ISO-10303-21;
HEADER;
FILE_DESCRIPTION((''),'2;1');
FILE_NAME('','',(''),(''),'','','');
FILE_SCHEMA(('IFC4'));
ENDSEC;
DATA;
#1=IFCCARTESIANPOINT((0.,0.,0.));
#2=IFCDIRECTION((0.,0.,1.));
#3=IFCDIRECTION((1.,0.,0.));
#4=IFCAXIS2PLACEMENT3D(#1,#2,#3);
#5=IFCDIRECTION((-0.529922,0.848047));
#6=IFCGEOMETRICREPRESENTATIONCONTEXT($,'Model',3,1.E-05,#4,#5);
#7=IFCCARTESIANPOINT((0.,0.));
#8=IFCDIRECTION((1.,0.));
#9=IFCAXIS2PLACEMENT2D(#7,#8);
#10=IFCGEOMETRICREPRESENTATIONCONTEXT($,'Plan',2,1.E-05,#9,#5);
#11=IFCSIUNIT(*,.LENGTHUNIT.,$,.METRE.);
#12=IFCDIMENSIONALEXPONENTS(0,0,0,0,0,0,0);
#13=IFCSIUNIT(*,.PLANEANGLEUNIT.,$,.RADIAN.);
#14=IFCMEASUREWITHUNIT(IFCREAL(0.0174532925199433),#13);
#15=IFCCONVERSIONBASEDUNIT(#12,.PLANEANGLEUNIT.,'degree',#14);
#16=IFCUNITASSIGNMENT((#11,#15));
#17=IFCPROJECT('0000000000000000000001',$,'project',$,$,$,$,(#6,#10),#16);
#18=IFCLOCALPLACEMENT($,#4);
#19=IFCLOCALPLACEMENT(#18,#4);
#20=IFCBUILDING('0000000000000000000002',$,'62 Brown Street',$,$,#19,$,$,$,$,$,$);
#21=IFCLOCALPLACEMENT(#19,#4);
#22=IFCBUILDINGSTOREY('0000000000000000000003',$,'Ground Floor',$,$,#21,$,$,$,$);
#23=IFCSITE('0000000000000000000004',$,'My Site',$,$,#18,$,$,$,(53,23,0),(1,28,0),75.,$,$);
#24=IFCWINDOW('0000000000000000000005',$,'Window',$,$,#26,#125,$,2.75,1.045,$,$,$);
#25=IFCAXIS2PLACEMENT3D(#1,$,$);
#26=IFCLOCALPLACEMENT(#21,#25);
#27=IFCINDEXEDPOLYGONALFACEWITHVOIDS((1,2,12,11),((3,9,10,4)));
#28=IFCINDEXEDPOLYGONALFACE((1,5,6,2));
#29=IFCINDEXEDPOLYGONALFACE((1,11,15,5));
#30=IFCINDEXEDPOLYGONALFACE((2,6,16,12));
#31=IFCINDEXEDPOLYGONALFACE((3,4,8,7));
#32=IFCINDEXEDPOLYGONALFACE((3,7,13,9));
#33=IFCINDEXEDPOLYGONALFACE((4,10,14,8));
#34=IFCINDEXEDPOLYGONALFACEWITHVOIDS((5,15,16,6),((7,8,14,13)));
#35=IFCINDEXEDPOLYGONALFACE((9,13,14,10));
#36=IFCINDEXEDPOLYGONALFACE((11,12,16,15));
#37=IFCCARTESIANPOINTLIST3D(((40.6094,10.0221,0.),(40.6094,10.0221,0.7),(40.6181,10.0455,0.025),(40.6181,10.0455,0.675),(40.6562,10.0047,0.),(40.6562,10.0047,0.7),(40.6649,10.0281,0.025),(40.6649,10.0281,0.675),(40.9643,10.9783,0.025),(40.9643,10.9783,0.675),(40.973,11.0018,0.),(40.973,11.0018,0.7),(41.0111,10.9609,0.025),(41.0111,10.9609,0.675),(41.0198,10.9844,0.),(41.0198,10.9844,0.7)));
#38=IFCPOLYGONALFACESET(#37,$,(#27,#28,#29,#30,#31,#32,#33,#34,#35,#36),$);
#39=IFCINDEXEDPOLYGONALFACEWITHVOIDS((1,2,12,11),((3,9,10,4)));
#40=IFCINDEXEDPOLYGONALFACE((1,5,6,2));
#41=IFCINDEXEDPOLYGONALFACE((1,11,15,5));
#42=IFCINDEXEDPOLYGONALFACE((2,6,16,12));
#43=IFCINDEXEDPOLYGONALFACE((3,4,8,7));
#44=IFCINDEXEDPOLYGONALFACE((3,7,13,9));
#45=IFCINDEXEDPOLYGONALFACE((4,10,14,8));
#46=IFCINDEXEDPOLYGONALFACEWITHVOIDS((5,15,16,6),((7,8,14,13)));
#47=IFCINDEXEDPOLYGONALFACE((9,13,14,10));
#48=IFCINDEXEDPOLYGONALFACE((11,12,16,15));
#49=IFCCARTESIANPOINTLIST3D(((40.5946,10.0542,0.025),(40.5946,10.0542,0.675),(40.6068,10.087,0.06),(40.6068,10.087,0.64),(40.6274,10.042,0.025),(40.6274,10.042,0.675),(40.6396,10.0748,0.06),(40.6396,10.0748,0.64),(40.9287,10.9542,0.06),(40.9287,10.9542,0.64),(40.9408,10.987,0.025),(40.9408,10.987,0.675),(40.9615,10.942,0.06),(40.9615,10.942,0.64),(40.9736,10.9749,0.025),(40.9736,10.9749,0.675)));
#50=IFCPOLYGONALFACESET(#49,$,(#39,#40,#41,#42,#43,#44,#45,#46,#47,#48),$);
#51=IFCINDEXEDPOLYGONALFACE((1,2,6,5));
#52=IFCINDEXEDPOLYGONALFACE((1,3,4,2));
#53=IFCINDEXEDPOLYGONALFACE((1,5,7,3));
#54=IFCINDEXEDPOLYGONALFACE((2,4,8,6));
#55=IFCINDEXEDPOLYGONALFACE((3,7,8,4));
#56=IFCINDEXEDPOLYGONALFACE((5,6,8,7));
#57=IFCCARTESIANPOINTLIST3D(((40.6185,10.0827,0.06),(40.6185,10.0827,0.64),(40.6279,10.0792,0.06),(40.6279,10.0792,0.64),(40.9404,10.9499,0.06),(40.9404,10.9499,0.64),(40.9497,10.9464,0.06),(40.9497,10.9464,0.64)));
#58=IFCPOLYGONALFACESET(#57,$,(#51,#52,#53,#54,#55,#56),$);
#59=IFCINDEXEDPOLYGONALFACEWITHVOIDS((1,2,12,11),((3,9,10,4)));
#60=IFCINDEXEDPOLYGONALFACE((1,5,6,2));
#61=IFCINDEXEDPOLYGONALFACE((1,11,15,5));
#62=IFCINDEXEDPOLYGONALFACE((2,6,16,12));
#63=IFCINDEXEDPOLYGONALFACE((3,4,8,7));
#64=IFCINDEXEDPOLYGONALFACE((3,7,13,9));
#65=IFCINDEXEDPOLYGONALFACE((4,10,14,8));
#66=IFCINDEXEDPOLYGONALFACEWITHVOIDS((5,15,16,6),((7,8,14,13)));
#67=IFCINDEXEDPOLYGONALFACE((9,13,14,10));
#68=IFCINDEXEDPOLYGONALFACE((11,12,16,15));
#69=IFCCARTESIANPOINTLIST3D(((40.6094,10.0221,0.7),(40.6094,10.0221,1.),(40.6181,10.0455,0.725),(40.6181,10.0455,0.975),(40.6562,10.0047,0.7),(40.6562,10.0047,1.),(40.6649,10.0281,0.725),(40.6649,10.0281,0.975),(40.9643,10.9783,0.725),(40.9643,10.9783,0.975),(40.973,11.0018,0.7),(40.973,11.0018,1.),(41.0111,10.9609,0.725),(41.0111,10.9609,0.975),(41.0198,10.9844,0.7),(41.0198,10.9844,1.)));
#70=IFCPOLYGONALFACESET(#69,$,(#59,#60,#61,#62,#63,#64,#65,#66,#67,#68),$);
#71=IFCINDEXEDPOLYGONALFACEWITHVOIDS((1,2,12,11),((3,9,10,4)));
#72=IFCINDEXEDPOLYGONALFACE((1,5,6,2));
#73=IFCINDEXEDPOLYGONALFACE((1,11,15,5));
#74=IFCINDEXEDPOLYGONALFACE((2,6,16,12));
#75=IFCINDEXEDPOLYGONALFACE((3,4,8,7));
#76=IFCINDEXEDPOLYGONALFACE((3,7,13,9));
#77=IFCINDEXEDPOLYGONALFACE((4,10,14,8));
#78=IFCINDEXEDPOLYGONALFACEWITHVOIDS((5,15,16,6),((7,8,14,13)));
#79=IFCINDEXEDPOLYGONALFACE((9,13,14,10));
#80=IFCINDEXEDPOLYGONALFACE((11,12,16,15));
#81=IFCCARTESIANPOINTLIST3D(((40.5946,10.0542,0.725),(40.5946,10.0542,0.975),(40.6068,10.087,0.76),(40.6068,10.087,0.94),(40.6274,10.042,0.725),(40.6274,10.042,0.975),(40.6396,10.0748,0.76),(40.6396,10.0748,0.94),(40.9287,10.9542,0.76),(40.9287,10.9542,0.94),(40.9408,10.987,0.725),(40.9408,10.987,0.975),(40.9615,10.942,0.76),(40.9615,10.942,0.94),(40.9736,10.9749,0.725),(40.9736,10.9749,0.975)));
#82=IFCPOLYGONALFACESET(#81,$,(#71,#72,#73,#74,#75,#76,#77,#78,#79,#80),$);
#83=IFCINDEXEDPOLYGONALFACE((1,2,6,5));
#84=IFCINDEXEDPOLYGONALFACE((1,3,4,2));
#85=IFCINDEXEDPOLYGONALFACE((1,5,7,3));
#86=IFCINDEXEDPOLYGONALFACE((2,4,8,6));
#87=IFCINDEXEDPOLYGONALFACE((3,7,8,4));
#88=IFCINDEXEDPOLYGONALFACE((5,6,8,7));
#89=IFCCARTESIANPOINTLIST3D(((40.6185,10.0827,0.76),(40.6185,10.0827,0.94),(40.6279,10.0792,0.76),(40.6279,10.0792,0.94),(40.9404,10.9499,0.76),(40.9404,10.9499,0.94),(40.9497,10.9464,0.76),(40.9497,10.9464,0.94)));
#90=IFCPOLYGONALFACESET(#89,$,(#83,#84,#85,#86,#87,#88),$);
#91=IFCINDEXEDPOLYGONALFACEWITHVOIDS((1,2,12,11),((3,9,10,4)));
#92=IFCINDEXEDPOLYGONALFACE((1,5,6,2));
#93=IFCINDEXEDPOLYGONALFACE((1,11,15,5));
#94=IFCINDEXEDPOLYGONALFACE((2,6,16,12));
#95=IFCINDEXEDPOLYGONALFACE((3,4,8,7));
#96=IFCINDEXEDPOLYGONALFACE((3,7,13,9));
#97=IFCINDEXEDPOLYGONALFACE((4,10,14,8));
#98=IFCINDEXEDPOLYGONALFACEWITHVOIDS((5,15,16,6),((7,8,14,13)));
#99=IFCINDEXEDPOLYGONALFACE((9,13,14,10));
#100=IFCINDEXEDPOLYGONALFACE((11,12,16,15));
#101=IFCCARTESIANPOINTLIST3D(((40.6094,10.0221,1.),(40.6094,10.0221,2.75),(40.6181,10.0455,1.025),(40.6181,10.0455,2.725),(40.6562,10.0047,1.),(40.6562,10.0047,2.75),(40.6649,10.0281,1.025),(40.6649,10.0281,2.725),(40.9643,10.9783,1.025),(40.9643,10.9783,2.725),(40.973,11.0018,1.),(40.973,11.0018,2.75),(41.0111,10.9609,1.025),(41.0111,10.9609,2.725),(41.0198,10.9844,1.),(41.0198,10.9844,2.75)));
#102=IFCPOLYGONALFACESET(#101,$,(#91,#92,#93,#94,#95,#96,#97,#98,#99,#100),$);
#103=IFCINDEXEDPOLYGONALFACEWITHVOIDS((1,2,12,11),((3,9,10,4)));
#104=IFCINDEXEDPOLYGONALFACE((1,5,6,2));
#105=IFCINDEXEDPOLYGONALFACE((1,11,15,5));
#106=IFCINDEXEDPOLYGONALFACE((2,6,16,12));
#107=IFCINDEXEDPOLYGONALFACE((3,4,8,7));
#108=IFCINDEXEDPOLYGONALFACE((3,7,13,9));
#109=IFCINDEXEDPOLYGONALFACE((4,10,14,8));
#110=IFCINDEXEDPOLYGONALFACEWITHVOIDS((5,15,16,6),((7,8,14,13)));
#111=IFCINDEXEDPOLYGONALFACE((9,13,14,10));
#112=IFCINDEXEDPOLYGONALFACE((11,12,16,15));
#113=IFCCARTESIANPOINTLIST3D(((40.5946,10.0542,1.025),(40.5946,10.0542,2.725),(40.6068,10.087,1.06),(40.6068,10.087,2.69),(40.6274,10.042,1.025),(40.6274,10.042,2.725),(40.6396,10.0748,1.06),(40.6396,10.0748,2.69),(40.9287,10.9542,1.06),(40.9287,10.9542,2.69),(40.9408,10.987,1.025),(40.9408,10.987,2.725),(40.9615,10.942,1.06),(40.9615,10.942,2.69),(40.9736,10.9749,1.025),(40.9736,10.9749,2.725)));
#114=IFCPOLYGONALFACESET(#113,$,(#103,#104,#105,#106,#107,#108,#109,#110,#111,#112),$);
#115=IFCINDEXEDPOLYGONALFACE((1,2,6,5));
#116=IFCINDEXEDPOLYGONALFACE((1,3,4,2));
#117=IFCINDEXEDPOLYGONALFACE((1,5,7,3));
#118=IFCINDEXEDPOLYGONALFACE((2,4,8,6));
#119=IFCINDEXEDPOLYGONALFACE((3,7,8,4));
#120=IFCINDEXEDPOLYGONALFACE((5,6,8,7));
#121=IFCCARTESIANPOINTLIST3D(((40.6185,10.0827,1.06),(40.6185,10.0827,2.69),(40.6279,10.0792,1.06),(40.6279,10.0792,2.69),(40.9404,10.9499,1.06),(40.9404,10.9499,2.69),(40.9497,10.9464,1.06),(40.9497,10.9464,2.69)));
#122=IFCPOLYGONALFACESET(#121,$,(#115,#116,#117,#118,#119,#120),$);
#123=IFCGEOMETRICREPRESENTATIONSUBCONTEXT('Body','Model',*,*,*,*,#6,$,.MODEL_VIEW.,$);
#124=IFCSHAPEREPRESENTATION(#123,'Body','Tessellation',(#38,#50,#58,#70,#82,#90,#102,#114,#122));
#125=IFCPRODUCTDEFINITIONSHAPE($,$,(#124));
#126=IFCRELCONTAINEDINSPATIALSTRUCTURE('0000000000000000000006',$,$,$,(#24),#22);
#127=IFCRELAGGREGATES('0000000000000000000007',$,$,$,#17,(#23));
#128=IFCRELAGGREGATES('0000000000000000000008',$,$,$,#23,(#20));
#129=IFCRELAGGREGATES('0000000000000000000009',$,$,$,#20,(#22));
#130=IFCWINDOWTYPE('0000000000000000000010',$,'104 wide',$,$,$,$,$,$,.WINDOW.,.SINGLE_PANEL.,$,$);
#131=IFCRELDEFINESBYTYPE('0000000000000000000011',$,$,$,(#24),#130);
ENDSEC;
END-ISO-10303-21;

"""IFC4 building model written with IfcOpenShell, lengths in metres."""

from ifc_helpers import new_model, entity, si_unit, converted_unit, direction, frame, origin_with_axes, origin_2d_with_axis, place, context, subcontext, project, spatial, line, indexed_curve, outline, extrude, shape, source, transform, mapped, type_object, type_shapes, element, save


model = new_model("IFC4")

# Units and contexts
model_context = context("Model", 3, precision=1e-05, world=origin_with_axes(), true_north=direction((-0.529922, 0.848047)))
plan_context = context("Plan", 2, precision=1e-05, world=origin_2d_with_axis(), true_north=direction((-0.529922, 0.848047)))
body_context_1 = subcontext(model_context, "Body", "Model", "MODEL_VIEW")
body_context_2 = subcontext(plan_context, "Body", "Plan", "PLAN_VIEW")
ifc_project = project(units=[si_unit("LENGTHUNIT", "METRE"), converted_unit("PLANEANGLEUNIT", "degree", entity("IfcReal", 0.0174532925199433), si_unit("PLANEANGLEUNIT", "RADIAN"), dimensions=[0, 0, 0, 0, 0, 0, 0])], contexts=[model_context, plan_context])

# Site, building, storey
site_placement = place(None, origin_with_axes())
site = spatial("IfcSite", under=ifc_project, at=site_placement, Name="My Site", RefLatitude=(53, 23, 0), RefLongitude=(1, 28, 0), RefElevation=75.0)
building_placement = place(site_placement, origin_with_axes())
building = spatial("IfcBuilding", under=site, at=building_placement, Name="62 Brown Street")
storey_placement = place(building_placement, origin_with_axes())
storey = spatial("IfcBuildingStorey", under=building, at=storey_placement, Name="Ground Floor")

# Window
window_type_1 = type_object("IfcWindowType", Name="104 wide", PartitioningType="SINGLE_PANEL", PredefinedType="WINDOW")
shared_shape_1 = source(origin_with_axes(), body_context_1, "Body", "SweptSolid", [
    extrude(outline(indexed_curve([(0.0, 0.0), (1.045, 0.0), (1.045, 0.7), (0.0, 0.7)], segments=[line(1, 2, 3, 4, 1)]), holes=[indexed_curve([(0.025, 0.025), (1.02, 0.025), (1.02, 0.675), (0.025, 0.675)], segments=[line(1, 2, 3, 4, 1)])]), frame((0.0, 0.15, 0.0), z_axis=(0.0, -1.0, 0.0), x_axis=(1.0, 0.0, 0.0)), (0.0, 0.0, -1.0), 0.05),
    extrude(outline(indexed_curve([(0.0, 0.0), (0.995, 0.0), (0.995, 0.65), (0.0, 0.65)], segments=[line(1, 2, 3, 4, 1)]), holes=[indexed_curve([(0.035, 0.035), (0.96, 0.035), (0.96, 0.615), (0.035, 0.615)], segments=[line(1, 2, 3, 4, 1)])]), frame((0.025, 0.19, 0.025), z_axis=(0.0, -1.0, 0.0), x_axis=(1.0, 0.0, 0.0)), (0.0, 0.0, -1.0), 0.035),
    extrude(outline(indexed_curve([(0.035, 0.035), (0.96, 0.035), (0.96, 0.615), (0.035, 0.615)], segments=[line(1, 2, 3, 4, 1)])), frame((0.025, 0.2025, 0.025), z_axis=(0.0, -1.0, 0.0), x_axis=(1.0, 0.0, 0.0)), (0.0, 0.0, -1.0), 0.01),
    extrude(outline(indexed_curve([(0.0, 0.0), (1.045, 0.0), (1.045, 0.3), (0.0, 0.3)], segments=[line(1, 2, 3, 4, 1)]), holes=[indexed_curve([(0.025, 0.025), (1.02, 0.025), (1.02, 0.275), (0.025, 0.275)], segments=[line(1, 2, 3, 4, 1)])]), frame((0.0, 0.15, 0.7), z_axis=(0.0, -1.0, 0.0), x_axis=(1.0, 0.0, 0.0)), (0.0, 0.0, -1.0), 0.05),
    extrude(outline(indexed_curve([(0.0, 0.0), (0.995, 0.0), (0.995, 0.25), (0.0, 0.25)], segments=[line(1, 2, 3, 4, 1)]), holes=[indexed_curve([(0.035, 0.035), (0.96, 0.035), (0.96, 0.215), (0.035, 0.215)], segments=[line(1, 2, 3, 4, 1)])]), frame((0.025, 0.19, 0.725), z_axis=(0.0, -1.0, 0.0), x_axis=(1.0, 0.0, 0.0)), (0.0, 0.0, -1.0), 0.035),
    extrude(outline(indexed_curve([(0.035, 0.035), (0.96, 0.035), (0.96, 0.215), (0.035, 0.215)], segments=[line(1, 2, 3, 4, 1)])), frame((0.025, 0.2025, 0.725), z_axis=(0.0, -1.0, 0.0), x_axis=(1.0, 0.0, 0.0)), (0.0, 0.0, -1.0), 0.01),
    extrude(outline(indexed_curve([(0.0, 0.0), (1.045, 0.0), (1.045, 1.75), (0.0, 1.75)], segments=[line(1, 2, 3, 4, 1)]), holes=[indexed_curve([(0.025, 0.025), (1.02, 0.025), (1.02, 1.725), (0.025, 1.725)], segments=[line(1, 2, 3, 4, 1)])]), frame((0.0, 0.15, 1.0), z_axis=(0.0, -1.0, 0.0), x_axis=(1.0, 0.0, 0.0)), (0.0, 0.0, -1.0), 0.05),
    extrude(outline(indexed_curve([(0.0, 0.0), (0.995, 0.0), (0.995, 1.7), (0.0, 1.7)], segments=[line(1, 2, 3, 4, 1)]), holes=[indexed_curve([(0.035, 0.035), (0.96, 0.035), (0.96, 1.665), (0.035, 1.665)], segments=[line(1, 2, 3, 4, 1)])]), frame((0.025, 0.19, 1.025), z_axis=(0.0, -1.0, 0.0), x_axis=(1.0, 0.0, 0.0)), (0.0, 0.0, -1.0), 0.035),
    extrude(outline(indexed_curve([(0.035, 0.035), (0.96, 0.035), (0.96, 1.665), (0.035, 1.665)], segments=[line(1, 2, 3, 4, 1)])), frame((0.025, 0.2025, 1.025), z_axis=(0.0, -1.0, 0.0), x_axis=(1.0, 0.0, 0.0)), (0.0, 0.0, -1.0), 0.01),
])
shared_shape_2 = source(origin_with_axes(), body_context_2, "Body", "Curve2D", [
    entity("IfcIndexedPolyCurve", entity("IfcCartesianPointList2D", [[0.025, 0.15], [1.02, 0.15]])),
    entity("IfcIndexedPolyCurve", entity("IfcCartesianPointList2D", [[0.0, 0.2], [0.025, 0.2], [0.025, 0.15], [0.0, 0.15]]), [entity("IfcLineIndex", [1, 2, 3, 4, 1])]),
    entity("IfcIndexedPolyCurve", entity("IfcCartesianPointList2D", [[1.045, 0.2], [1.02, 0.2], [1.02, 0.15], [1.045, 0.15]]), [entity("IfcLineIndex", [1, 2, 3, 4, 1])]),
    entity("IfcIndexedPolyCurve", entity("IfcCartesianPointList2D", [[0.025, 0.19], [0.06, 0.19], [0.06, 0.225], [0.025, 0.225]]), [entity("IfcLineIndex", [1, 2, 3, 4, 1])]),
    entity("IfcIndexedPolyCurve", entity("IfcCartesianPointList2D", [[1.02, 0.19], [0.985, 0.19], [0.985, 0.225], [1.02, 0.225]]), [entity("IfcLineIndex", [1, 2, 3, 4, 1])]),
    entity("IfcIndexedPolyCurve", entity("IfcCartesianPointList2D", [[0.06, 0.19], [0.985, 0.19]])),
    entity("IfcIndexedPolyCurve", entity("IfcCartesianPointList2D", [[0.06, 0.225], [0.985, 0.225]])),
    entity("IfcIndexedPolyCurve", entity("IfcCartesianPointList2D", [[0.06, 0.2075], [0.985, 0.2075]])),
])
type_shapes(window_type_1, [shared_shape_1, shared_shape_2])
placement_1 = place(storey_placement, frame((39.024, 5.1755, 0.0), z_axis=(0.0, 0.0, 1.0), x_axis=(0.347944, 0.937515, 0.0)))
placement_2 = place(placement_1, frame((5.0954, 0.0, 0.0), z_axis=(0.0, 0.0, 1.0), x_axis=(1.0, 0.0, 0.0)))
window_1_placement = place(placement_2, origin_with_axes())
element("IfcWindow", 1, at=window_1_placement, inside=storey, type_object=window_type_1, Name="Window", OverallHeight=2.75, OverallWidth=1.045, shapes=[
    shape(body_context_1, "Body", "MappedRepresentation", [mapped(shared_shape_1, transform((0.0, 0.0, 0.0), x_axis=(1.0, 0.0, 0.0), y_axis=(0.0, 1.0, 0.0), z_axis=(0.0, 0.0, 1.0), scale=1.0))]),
    shape(body_context_2, "Body", "MappedRepresentation", [mapped(shared_shape_2, transform((0.0, 0.0, 0.0), x_axis=(1.0, 0.0, 0.0), y_axis=(0.0, 1.0, 0.0), z_axis=(0.0, 0.0, 1.0), scale=1.0))]),
])

save(model, "model.ifc")
